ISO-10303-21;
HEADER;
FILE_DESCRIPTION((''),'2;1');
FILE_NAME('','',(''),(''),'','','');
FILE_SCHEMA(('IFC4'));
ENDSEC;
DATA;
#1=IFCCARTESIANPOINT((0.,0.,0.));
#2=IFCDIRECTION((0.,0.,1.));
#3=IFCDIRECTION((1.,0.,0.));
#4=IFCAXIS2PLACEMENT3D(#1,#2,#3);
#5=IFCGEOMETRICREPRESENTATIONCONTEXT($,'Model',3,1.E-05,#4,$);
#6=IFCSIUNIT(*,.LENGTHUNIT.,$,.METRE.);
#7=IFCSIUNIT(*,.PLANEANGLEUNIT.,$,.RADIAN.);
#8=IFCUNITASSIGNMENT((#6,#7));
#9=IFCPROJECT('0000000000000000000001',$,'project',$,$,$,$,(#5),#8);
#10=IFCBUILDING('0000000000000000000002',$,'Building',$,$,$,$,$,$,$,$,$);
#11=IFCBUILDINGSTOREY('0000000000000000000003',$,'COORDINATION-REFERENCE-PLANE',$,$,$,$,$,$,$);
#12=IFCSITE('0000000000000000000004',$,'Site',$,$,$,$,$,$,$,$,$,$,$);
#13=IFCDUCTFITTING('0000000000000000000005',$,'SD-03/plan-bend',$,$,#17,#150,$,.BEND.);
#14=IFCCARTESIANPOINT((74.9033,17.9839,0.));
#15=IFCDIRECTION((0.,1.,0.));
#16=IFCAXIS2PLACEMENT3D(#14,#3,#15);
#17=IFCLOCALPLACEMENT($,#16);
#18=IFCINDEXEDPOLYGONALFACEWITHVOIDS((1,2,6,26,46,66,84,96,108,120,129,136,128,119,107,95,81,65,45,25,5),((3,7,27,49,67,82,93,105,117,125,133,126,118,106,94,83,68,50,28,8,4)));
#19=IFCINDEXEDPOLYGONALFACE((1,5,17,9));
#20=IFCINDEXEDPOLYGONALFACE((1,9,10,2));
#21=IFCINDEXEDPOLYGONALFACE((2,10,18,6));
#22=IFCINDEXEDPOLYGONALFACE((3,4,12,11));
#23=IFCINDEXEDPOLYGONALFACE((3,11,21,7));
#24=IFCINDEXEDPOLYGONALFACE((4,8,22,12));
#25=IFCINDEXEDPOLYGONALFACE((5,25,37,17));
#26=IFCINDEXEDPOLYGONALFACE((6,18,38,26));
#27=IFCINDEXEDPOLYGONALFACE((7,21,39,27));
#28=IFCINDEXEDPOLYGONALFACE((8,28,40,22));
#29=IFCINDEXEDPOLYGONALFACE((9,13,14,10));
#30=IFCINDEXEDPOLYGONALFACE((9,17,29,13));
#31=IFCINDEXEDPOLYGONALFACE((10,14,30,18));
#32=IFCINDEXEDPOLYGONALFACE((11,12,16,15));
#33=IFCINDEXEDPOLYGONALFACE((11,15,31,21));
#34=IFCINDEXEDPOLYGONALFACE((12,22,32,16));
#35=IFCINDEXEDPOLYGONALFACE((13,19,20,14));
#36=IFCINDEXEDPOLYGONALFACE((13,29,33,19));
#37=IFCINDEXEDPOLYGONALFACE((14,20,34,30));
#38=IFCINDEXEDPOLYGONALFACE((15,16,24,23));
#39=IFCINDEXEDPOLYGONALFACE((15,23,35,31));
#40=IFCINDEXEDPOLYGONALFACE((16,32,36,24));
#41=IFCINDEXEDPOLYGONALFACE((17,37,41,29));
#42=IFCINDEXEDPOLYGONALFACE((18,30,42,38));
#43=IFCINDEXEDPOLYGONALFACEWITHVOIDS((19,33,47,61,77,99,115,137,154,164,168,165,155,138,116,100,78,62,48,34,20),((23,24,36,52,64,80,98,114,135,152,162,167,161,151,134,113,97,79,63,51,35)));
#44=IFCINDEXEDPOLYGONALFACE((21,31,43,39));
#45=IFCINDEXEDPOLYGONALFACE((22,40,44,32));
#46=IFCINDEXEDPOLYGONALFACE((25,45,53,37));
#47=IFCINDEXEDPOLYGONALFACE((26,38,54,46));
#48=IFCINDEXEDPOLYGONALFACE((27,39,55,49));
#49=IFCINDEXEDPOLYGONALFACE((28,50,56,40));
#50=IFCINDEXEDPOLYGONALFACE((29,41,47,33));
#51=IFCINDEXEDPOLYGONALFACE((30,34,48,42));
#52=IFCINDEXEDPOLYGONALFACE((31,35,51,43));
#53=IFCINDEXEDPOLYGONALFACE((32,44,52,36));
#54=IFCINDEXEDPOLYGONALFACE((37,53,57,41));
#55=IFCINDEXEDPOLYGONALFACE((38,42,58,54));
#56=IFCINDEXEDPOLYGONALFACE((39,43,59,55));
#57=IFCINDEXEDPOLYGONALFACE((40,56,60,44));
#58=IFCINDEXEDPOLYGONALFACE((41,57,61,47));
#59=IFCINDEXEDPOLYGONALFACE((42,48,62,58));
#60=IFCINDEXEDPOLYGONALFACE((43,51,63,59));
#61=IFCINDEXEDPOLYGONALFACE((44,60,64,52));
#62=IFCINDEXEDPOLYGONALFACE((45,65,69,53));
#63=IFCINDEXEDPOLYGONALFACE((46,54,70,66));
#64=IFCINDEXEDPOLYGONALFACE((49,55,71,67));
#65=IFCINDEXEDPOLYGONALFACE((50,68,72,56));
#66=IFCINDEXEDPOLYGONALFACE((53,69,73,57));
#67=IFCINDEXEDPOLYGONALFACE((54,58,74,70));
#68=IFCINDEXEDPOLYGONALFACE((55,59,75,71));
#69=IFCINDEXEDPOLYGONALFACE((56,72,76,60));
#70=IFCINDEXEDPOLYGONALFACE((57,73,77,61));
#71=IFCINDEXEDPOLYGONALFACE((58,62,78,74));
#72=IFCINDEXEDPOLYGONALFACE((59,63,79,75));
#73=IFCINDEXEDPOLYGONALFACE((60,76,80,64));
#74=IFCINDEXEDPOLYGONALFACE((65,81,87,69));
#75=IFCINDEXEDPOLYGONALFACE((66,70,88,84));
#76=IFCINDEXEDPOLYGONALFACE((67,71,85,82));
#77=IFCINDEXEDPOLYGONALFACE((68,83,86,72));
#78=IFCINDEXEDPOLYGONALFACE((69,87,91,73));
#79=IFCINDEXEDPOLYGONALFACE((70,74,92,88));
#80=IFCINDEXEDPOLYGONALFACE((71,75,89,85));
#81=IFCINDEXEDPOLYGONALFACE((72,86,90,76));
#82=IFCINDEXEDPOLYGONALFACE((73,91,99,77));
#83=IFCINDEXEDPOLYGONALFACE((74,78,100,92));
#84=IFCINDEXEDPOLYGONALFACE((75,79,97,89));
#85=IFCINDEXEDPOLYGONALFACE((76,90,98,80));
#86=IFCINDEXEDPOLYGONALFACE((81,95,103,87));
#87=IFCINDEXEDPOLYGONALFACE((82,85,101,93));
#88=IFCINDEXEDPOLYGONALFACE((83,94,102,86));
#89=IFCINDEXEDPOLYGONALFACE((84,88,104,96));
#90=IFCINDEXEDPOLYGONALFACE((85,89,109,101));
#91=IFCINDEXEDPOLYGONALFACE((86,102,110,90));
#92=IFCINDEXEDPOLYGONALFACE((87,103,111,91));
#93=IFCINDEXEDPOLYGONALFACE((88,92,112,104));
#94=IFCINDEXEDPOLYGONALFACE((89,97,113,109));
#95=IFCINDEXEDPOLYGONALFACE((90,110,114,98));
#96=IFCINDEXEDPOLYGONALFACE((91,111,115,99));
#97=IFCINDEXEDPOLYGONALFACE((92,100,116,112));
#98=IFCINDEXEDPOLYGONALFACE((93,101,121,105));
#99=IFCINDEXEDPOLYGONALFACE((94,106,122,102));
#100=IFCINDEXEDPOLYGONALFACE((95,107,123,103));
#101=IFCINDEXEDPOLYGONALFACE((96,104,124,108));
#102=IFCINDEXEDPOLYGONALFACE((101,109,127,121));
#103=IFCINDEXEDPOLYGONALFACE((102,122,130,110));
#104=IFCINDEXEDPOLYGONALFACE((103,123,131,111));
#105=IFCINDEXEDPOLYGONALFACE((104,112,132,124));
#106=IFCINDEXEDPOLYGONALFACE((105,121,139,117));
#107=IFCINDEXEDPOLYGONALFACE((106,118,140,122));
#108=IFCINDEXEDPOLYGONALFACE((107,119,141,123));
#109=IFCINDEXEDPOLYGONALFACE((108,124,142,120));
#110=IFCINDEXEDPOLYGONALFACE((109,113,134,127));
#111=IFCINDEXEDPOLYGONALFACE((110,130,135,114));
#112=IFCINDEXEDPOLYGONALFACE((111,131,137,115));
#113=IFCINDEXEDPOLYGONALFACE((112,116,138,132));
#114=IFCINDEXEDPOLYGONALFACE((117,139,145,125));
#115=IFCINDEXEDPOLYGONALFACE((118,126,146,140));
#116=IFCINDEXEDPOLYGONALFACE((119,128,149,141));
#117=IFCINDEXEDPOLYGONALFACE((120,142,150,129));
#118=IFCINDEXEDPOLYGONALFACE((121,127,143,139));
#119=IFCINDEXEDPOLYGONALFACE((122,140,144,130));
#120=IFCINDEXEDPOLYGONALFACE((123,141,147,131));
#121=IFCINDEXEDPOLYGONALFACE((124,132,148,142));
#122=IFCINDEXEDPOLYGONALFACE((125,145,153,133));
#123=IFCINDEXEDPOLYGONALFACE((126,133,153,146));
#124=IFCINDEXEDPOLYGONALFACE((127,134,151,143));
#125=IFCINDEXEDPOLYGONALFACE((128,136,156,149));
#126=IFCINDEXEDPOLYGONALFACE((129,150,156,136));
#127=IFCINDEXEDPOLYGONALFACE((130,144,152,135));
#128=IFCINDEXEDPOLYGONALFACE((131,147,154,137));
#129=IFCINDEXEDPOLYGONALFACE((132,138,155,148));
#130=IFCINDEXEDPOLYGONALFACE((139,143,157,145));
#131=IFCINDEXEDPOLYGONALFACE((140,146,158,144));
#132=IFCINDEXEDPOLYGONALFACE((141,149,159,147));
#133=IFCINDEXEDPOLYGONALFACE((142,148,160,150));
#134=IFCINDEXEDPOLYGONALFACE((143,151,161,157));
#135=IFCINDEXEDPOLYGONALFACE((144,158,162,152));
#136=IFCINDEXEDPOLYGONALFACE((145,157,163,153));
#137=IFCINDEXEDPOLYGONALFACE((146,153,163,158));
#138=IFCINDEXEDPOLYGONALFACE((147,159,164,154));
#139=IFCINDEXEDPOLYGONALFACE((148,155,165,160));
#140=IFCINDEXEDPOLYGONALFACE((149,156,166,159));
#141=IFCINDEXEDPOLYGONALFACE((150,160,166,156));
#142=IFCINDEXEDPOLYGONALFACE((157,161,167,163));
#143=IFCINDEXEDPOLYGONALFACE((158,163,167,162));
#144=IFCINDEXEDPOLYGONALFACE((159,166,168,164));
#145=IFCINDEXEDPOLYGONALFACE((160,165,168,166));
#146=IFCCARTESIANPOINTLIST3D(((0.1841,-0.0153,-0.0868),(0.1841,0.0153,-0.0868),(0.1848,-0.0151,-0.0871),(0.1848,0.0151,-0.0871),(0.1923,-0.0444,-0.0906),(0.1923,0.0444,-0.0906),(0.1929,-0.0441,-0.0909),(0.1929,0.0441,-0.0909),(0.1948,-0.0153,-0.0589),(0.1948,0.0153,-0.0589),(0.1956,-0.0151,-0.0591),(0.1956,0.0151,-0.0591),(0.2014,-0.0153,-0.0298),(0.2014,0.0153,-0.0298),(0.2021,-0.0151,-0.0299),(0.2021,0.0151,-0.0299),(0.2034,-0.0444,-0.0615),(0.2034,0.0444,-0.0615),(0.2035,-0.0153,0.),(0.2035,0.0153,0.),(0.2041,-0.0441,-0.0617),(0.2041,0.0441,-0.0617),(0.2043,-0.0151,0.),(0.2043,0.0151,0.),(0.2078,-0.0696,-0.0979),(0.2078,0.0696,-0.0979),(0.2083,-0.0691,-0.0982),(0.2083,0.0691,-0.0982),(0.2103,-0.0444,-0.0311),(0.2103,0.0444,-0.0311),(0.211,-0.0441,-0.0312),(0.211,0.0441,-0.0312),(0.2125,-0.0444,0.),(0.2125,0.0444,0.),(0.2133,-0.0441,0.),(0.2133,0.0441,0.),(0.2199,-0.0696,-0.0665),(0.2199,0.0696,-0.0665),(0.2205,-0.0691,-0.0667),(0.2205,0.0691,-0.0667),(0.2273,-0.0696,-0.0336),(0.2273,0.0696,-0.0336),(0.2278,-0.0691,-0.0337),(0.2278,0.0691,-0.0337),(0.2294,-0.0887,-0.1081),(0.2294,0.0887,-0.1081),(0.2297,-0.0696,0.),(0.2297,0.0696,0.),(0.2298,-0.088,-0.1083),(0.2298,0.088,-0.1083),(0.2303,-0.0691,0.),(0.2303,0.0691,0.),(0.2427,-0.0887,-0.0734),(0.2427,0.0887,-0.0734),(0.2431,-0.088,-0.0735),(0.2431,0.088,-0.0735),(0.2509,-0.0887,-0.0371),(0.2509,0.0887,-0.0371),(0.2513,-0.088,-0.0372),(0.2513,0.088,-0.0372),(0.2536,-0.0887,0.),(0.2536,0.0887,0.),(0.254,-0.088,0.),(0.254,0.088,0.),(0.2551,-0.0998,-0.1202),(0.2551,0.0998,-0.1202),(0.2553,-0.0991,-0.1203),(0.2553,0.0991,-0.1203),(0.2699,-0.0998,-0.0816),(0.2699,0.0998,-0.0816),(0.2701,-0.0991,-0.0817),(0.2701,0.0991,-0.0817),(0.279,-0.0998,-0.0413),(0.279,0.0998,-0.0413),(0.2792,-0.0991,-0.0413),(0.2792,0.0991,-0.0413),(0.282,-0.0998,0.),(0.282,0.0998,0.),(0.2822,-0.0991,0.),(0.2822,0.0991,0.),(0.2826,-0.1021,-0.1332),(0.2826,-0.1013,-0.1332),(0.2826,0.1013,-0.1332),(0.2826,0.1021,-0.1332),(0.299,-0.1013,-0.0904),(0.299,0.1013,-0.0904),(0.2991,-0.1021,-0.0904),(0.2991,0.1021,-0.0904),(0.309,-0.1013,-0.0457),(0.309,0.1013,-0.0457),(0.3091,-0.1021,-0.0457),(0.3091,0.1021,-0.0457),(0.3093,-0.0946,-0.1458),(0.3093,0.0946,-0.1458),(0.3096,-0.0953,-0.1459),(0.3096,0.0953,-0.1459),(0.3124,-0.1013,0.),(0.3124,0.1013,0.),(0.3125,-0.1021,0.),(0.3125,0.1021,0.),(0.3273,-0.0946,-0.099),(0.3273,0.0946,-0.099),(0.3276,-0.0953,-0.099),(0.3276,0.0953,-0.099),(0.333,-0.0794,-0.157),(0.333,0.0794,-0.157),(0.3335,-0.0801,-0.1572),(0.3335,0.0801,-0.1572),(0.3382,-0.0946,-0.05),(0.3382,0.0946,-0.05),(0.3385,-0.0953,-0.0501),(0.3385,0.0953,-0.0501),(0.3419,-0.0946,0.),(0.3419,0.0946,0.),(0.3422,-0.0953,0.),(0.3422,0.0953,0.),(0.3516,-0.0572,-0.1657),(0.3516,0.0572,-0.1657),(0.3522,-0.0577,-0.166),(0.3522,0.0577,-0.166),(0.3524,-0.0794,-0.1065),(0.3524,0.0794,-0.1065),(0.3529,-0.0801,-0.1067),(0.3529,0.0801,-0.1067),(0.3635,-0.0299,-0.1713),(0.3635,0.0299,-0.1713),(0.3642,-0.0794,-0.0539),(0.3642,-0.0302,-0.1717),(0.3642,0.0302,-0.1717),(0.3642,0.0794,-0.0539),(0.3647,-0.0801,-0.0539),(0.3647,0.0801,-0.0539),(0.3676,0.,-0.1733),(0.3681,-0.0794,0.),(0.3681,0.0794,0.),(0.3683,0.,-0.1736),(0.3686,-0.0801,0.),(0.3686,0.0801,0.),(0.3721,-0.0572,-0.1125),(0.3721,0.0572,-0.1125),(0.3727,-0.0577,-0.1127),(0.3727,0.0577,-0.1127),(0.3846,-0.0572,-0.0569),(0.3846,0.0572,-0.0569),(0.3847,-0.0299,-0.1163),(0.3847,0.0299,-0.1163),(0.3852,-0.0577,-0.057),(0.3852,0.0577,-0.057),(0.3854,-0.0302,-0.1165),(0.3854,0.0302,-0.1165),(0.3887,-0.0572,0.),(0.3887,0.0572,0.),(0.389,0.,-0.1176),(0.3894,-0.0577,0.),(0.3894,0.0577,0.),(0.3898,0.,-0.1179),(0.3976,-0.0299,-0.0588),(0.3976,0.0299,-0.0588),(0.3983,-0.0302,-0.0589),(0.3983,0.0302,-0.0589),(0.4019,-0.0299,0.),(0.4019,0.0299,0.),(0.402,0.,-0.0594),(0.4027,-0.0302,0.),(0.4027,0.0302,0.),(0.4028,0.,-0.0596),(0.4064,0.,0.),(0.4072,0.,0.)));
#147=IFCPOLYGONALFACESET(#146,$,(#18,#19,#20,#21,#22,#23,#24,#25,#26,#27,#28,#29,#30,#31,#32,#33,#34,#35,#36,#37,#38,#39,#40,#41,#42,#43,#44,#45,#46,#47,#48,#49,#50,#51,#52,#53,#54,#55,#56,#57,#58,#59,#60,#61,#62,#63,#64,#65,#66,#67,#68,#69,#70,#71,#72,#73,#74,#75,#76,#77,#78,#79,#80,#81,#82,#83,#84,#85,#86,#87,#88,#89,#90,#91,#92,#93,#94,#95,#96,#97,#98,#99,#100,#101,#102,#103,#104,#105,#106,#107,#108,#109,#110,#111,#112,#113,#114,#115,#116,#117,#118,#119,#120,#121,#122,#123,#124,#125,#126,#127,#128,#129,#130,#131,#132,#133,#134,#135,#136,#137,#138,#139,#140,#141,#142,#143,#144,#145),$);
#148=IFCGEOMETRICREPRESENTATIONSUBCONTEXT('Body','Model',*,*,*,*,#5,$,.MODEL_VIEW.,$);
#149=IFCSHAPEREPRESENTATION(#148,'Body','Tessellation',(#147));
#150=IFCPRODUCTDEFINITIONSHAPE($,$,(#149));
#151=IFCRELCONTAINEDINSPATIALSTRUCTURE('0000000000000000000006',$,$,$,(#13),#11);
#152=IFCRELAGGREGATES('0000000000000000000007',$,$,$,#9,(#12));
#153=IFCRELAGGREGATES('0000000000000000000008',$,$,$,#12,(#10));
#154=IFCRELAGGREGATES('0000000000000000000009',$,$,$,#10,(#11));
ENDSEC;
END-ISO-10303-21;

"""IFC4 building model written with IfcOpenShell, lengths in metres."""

from ifc_helpers import new_model, entity, si_unit, frame, origin_with_axes, place, context, subcontext, project, spatial, element, save


model = new_model("IFC4")

# Units and contexts
model_context = context("Model", 3, precision=1e-05, world=origin_with_axes())
body_context_1 = subcontext(model_context, "Body", "Model", "MODEL_VIEW")
ifc_project = project(units=[si_unit("LENGTHUNIT", "METRE"), si_unit("PLANEANGLEUNIT", "RADIAN")], contexts=[model_context])

# Site, building, storey
site = spatial("IfcSite", under=ifc_project, Name="Site")
building = spatial("IfcBuilding", under=site, Name="Building")
storey = spatial("IfcBuildingStorey", under=building, Name="COORDINATION-REFERENCE-PLANE")

# Duct fitting
duct_fitting_1_placement = place(None, frame((74.9033, 17.9839, 0.0), z_axis=(1.0, 0.0, 0.0), x_axis=(0.0, 1.0, 0.0)))
element("IfcDuctFitting", 1, at=duct_fitting_1_placement, inside=storey, Name="SD-03/plan-bend", PredefinedType="BEND", context=body_context_1, shape_type="SweptSolid", body=[
    entity("IfcRevolvedAreaSolid", entity("IfcCircleHollowProfileDef", "AREA", None, entity("IfcAxis2Placement2D", entity("IfcCartesianPoint", [0.3048, 0.0])), 0.1024, 0.0008), entity("IfcAxis2Placement3D", entity("IfcCartesianPoint", [0.0, 0.0, 0.0]), entity("IfcDirection", [0.0, 0.0, 1.0]), entity("IfcDirection", [1.0, 0.0, 0.0])), entity("IfcAxis1Placement", entity("IfcCartesianPoint", [0.0, 0.0, 0.0]), entity("IfcDirection", [0.0, 1.0, 0.0])), 0.440428),
])

save(model, "model.ifc")
